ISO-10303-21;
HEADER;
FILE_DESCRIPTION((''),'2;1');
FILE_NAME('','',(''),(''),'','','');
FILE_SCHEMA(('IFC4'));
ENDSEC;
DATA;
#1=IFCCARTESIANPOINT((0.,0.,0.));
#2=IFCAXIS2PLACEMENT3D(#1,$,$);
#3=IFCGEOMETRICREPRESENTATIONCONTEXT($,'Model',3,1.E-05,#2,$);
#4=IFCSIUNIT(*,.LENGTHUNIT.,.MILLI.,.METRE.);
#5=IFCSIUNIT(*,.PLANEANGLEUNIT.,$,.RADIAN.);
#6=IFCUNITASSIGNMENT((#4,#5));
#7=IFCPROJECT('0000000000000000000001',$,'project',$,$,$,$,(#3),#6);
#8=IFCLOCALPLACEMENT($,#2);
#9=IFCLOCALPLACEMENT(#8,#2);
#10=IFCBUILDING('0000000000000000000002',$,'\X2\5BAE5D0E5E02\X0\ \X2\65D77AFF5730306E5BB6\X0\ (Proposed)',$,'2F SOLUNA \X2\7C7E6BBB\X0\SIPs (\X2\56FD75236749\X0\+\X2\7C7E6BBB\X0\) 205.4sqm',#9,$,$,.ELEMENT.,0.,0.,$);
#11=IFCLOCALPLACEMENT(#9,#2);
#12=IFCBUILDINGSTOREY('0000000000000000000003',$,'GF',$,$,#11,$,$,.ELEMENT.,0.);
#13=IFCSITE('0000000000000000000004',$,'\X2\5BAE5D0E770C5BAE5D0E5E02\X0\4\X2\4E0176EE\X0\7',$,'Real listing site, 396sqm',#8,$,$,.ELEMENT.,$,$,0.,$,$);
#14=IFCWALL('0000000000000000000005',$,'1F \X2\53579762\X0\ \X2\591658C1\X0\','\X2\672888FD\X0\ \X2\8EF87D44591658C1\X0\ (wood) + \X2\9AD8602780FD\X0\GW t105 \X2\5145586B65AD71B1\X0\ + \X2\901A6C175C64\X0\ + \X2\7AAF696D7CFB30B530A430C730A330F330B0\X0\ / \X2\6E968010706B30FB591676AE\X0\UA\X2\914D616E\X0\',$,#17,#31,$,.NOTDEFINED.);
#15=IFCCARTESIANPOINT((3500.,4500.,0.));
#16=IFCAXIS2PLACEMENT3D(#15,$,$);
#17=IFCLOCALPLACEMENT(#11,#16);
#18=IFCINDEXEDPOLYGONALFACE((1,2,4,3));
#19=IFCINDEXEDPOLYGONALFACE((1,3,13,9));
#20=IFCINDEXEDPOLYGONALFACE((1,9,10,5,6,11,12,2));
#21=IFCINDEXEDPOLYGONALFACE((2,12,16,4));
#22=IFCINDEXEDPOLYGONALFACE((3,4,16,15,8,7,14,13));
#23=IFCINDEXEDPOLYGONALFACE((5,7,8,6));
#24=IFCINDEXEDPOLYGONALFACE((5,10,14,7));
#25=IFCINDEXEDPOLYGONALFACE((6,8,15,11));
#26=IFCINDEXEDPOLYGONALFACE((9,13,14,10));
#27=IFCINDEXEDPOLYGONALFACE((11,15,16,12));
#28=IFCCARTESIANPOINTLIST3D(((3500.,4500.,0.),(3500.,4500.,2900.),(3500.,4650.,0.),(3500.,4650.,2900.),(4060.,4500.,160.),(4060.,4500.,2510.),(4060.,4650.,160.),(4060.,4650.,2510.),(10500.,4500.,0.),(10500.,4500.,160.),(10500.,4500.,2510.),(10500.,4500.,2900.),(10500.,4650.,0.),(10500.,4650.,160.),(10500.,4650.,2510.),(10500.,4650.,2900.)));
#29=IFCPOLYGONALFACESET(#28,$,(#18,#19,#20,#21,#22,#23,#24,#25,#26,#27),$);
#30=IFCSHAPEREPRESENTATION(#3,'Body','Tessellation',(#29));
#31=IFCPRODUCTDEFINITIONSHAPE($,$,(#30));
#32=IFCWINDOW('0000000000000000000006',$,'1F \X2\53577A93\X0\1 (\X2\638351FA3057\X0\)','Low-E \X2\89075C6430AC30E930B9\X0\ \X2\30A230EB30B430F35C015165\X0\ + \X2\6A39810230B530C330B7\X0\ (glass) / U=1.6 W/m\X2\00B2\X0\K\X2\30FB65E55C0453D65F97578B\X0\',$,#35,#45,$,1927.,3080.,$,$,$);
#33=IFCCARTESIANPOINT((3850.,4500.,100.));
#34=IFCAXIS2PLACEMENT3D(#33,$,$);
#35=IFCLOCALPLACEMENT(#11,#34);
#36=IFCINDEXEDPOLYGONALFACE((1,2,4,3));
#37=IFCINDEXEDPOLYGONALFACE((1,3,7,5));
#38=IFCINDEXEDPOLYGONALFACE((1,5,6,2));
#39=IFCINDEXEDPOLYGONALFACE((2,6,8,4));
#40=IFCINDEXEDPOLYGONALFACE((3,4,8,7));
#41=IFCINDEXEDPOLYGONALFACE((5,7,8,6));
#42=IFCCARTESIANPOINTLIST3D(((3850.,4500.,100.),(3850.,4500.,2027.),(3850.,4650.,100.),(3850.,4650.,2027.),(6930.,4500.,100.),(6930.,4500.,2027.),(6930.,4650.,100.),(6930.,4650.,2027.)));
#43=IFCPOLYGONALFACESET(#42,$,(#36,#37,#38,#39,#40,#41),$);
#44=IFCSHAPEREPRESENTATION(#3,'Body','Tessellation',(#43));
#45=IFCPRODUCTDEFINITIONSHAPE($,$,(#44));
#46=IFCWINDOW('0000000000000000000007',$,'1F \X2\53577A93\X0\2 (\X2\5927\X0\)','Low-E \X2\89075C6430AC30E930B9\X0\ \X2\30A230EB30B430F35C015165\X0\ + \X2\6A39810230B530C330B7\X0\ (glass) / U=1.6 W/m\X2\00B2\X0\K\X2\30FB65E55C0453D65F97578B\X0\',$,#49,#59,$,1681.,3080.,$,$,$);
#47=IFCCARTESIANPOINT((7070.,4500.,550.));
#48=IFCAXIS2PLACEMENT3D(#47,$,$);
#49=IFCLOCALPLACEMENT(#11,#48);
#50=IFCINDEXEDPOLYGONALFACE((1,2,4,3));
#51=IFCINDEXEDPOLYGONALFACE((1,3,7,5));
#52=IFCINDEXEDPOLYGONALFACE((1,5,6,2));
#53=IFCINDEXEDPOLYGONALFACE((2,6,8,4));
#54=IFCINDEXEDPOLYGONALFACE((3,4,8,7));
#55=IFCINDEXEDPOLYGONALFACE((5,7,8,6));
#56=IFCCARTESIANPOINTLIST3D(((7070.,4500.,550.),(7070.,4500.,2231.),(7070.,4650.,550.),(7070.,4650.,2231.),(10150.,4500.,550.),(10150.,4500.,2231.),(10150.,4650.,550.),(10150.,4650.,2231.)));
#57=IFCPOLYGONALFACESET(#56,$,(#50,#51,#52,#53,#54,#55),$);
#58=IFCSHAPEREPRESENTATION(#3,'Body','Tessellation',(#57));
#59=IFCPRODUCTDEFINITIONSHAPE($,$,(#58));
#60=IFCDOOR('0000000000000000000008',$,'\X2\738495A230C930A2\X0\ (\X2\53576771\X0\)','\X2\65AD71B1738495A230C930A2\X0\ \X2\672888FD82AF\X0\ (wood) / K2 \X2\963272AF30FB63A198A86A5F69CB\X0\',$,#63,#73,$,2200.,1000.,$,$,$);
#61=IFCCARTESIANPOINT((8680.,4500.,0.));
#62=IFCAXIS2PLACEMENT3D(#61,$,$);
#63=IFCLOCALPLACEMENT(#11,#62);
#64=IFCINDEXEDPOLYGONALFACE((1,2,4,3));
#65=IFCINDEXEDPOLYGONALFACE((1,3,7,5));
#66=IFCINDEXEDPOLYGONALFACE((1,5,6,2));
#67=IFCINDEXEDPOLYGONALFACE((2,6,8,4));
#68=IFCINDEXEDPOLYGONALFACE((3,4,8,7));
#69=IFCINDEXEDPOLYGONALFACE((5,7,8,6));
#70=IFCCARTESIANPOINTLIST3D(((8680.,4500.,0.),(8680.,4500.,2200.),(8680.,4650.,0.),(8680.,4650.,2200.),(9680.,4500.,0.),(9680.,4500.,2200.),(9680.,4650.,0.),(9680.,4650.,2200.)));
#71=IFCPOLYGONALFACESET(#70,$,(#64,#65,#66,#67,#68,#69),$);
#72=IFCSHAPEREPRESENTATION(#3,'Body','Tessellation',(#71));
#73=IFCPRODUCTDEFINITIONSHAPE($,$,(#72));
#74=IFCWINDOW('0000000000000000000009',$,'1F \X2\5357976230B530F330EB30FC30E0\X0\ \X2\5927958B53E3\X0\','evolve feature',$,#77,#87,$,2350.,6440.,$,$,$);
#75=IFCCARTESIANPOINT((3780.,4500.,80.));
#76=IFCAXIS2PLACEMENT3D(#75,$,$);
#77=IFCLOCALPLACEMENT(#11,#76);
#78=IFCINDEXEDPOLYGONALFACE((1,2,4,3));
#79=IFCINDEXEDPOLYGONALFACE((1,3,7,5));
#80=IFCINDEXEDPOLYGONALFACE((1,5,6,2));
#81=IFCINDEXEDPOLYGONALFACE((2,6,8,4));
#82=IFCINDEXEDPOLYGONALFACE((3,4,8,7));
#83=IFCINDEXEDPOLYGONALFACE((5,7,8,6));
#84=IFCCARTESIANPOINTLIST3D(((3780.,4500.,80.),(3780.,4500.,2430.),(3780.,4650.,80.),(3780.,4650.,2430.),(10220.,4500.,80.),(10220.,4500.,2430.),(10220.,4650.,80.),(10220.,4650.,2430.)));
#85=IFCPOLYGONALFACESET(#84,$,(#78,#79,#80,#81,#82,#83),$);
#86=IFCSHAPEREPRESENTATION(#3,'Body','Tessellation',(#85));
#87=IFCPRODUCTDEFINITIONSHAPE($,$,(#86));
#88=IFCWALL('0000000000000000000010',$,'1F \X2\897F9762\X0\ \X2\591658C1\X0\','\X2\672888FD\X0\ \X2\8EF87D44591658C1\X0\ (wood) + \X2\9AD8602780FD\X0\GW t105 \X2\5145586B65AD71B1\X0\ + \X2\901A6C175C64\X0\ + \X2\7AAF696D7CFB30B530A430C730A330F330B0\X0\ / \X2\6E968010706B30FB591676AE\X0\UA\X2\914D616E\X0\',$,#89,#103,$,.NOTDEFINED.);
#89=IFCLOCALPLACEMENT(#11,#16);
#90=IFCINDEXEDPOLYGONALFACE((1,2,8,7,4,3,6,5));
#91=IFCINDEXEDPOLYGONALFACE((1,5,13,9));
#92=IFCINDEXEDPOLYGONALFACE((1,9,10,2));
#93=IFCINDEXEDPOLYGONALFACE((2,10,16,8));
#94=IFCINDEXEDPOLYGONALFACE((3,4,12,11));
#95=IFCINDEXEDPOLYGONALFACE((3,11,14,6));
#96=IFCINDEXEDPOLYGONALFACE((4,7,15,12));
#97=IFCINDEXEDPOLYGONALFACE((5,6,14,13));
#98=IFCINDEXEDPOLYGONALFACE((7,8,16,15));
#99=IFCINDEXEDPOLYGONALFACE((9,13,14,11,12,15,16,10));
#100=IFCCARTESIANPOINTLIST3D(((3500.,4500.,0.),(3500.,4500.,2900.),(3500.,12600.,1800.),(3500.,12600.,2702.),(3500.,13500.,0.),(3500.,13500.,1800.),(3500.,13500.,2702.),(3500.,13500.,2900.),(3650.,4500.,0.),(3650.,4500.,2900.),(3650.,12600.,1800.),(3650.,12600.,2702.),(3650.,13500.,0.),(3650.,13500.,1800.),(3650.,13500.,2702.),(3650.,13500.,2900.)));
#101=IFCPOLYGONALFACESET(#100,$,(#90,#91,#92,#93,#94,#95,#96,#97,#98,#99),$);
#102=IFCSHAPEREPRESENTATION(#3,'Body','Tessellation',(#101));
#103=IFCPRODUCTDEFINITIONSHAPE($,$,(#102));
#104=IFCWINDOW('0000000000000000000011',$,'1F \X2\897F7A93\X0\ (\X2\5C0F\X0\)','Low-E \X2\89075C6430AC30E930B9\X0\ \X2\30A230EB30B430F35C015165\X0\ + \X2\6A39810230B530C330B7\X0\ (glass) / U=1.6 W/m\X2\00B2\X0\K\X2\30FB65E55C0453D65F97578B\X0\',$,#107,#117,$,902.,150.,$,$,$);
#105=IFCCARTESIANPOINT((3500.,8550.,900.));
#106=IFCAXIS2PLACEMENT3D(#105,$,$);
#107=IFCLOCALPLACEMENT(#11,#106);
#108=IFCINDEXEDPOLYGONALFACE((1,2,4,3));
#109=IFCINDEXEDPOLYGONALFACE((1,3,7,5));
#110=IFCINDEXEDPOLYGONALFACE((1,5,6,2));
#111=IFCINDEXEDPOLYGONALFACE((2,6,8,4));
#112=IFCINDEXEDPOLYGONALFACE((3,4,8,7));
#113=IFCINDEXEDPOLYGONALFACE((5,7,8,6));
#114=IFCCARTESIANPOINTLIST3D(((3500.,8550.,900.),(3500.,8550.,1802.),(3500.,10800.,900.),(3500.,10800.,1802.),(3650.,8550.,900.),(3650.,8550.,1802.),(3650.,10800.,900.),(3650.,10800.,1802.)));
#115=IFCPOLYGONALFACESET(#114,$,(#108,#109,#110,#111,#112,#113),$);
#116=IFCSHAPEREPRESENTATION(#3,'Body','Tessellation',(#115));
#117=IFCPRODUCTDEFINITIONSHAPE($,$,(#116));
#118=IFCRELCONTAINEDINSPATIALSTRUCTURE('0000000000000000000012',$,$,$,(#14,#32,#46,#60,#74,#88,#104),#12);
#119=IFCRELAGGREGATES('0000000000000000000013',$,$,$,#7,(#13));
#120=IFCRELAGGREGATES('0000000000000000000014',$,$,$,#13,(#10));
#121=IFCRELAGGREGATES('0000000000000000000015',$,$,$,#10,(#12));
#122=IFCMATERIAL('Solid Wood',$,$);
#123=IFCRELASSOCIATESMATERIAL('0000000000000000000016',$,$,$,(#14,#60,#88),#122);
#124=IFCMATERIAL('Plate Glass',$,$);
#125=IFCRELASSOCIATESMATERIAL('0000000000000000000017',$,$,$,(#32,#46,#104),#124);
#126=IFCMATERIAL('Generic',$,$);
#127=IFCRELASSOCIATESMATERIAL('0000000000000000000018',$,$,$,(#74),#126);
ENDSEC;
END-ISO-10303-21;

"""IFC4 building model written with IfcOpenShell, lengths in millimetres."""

from ifc_helpers import new_model, si_unit, frame, frame_2d, origin, place, context, project, spatial, rectangle, extrude, material, element, fill, save


model = new_model("IFC4")

# Units and contexts
model_context = context("Model", 3, precision=1e-05, world=origin())
ifc_project = project(units=[si_unit("LENGTHUNIT", "METRE", prefix="MILLI"), si_unit("PLANEANGLEUNIT", "RADIAN")], contexts=[model_context])

# Site, building, storey
site_placement = place(None, origin())
site = spatial("IfcSite", under=ifc_project, at=site_placement, Name="宮崎県宮崎市4丁目7", ObjectType="Real listing site, 396sqm", CompositionType="ELEMENT", RefElevation=0.0)
building_placement = place(site_placement, origin())
building = spatial("IfcBuilding", under=site, at=building_placement, Name="宮崎市 旗竿地の家 (Proposed)", ObjectType="2F SOLUNA 籾殻SIPs (国産杉+籾殻) 205.4sqm", CompositionType="ELEMENT", ElevationOfRefHeight=0.0, ElevationOfTerrain=0.0)
storey_placement = place(building_placement, origin())
storey = spatial("IfcBuildingStorey", under=building, at=storey_placement, Name="GF", CompositionType="ELEMENT", Elevation=0.0)

# Shared definitions
ifc_material_1 = material(Name="Solid Wood")

# Wall, openings, windows, door
wall_1_placement = place(storey_placement, frame((3500.0, 4500.0, 0.0)))
wall_1 = element("IfcWall", 1, at=wall_1_placement, inside=storey, material=ifc_material_1, Name="1F 南面 外壁", Description="木製 軸組外壁 (wood) + 高性能GW t105 充填断熱 + 通気層 + 窯業系サイディング / 準耐火・外皮UA配慮", PredefinedType="NOTDEFINED", context=model_context, shape_type="SweptSolid", body=[
    extrude(rectangle(XDim=7000.0, YDim=150.0, at=frame_2d((3500.0, 75.0))), frame((3500.0, 4500.0, 0.0)), (0.0, 0.0, 1.0), 2900.0),
])
opening_1_placement = place(storey_placement, frame((3850.0, 4500.0, 100.0)))
opening_1 = element("IfcOpeningElement", 2, at=opening_1_placement, cuts=wall_1, PredefinedType="NOTDEFINED", context=model_context, shape_type="SweptSolid", body=[
    extrude(rectangle(XDim=3080.0, YDim=150.0, at=frame_2d((1540.0, 75.0))), frame((3850.0, 4500.0, 100.0)), (0.0, 0.0, 1.0), 1927.0),
])
opening_2_placement = place(storey_placement, frame((7070.0, 4500.0, 550.0)))
opening_2 = element("IfcOpeningElement", 3, at=opening_2_placement, cuts=wall_1, PredefinedType="NOTDEFINED", context=model_context, shape_type="SweptSolid", body=[
    extrude(rectangle(XDim=3080.0, YDim=150.0, at=frame_2d((1540.0, 75.0))), frame((7070.0, 4500.0, 550.0)), (0.0, 0.0, 1.0), 1681.0),
])
opening_3_placement = place(storey_placement, frame((8680.0, 4500.0, 0.0)))
opening_3 = element("IfcOpeningElement", 4, at=opening_3_placement, cuts=wall_1, PredefinedType="NOTDEFINED", context=model_context, shape_type="SweptSolid", body=[
    extrude(rectangle(XDim=1000.0, YDim=150.0, at=frame_2d((500.0, 75.0))), frame((8680.0, 4500.0, 0.0)), (0.0, 0.0, 1.0), 2200.0),
])
opening_4_placement = place(storey_placement, frame((3780.0, 4500.0, 80.0)))
opening_4 = element("IfcOpeningElement", 5, at=opening_4_placement, cuts=wall_1, PredefinedType="NOTDEFINED", context=model_context, shape_type="SweptSolid", body=[
    extrude(rectangle(XDim=6440.0, YDim=150.0, at=frame_2d((3220.0, 75.0))), frame((3780.0, 4500.0, 80.0)), (0.0, 0.0, 1.0), 2350.0),
])
ifc_material_2 = material(Name="Plate Glass")
window_1_placement = place(storey_placement, frame((3850.0, 4500.0, 100.0)))
window_1 = element("IfcWindow", 6, at=window_1_placement, inside=storey, material=ifc_material_2, Name="1F 南窓1 (掃出し)", Description="Low-E 複層ガラス アルゴン封入 + 樹脂サッシ (glass) / U=1.6 W/m²K・日射取得型", OverallHeight=1927.0, OverallWidth=3080.0, context=model_context, shape_type="SweptSolid", body=[
    extrude(rectangle(XDim=3080.0, YDim=150.0, at=frame_2d((1540.0, 75.0))), frame((3850.0, 4500.0, 100.0)), (0.0, 0.0, 1.0), 1927.0),
])
fill(opening_1, window_1)
window_2_placement = place(storey_placement, frame((7070.0, 4500.0, 550.0)))
window_2 = element("IfcWindow", 7, at=window_2_placement, inside=storey, material=ifc_material_2, Name="1F 南窓2 (大)", Description="Low-E 複層ガラス アルゴン封入 + 樹脂サッシ (glass) / U=1.6 W/m²K・日射取得型", OverallHeight=1681.0, OverallWidth=3080.0, context=model_context, shape_type="SweptSolid", body=[
    extrude(rectangle(XDim=3080.0, YDim=150.0, at=frame_2d((1540.0, 75.0))), frame((7070.0, 4500.0, 550.0)), (0.0, 0.0, 1.0), 1681.0),
])
fill(opening_2, window_2)
door_placement = place(storey_placement, frame((8680.0, 4500.0, 0.0)))
door = element("IfcDoor", 8, at=door_placement, inside=storey, material=ifc_material_1, Name="玄関ドア (南東)", Description="断熱玄関ドア 木製芯 (wood) / K2 防犯・採風機構", OverallHeight=2200.0, OverallWidth=1000.0, context=model_context, shape_type="SweptSolid", body=[
    extrude(rectangle(XDim=1000.0, YDim=150.0, at=frame_2d((500.0, 75.0))), frame((8680.0, 4500.0, 0.0)), (0.0, 0.0, 1.0), 2200.0),
])
fill(opening_3, door)
ifc_material_3 = material(Name="Generic")
window_3_placement = place(storey_placement, frame((3780.0, 4500.0, 80.0)))
window_3 = element("IfcWindow", 9, at=window_3_placement, inside=storey, material=ifc_material_3, Name="1F 南面サンルーム 大開口", Description="evolve feature", OverallHeight=2350.0, OverallWidth=6440.0, context=model_context, shape_type="SweptSolid", body=[
    extrude(rectangle(XDim=6440.0, YDim=150.0, at=frame_2d((3220.0, 75.0))), frame((3780.0, 4500.0, 80.0)), (0.0, 0.0, 1.0), 2350.0),
])
fill(opening_4, window_3)

# Wall, opening, window
wall_2_placement = place(storey_placement, frame((3500.0, 4500.0, 0.0)))
wall_2 = element("IfcWall", 10, at=wall_2_placement, inside=storey, material=ifc_material_1, Name="1F 西面 外壁", Description="木製 軸組外壁 (wood) + 高性能GW t105 充填断熱 + 通気層 + 窯業系サイディング / 準耐火・外皮UA配慮", PredefinedType="NOTDEFINED", context=model_context, shape_type="SweptSolid", body=[
    extrude(rectangle(XDim=150.0, YDim=9000.0, at=frame_2d((75.0, 4500.0))), frame((3500.0, 4500.0, 0.0)), (0.0, 0.0, 1.0), 2900.0),
])
opening_5_placement = place(storey_placement, frame((3500.0, 8550.0, 900.0)))
opening_5 = element("IfcOpeningElement", 11, at=opening_5_placement, cuts=wall_2, PredefinedType="NOTDEFINED", context=model_context, shape_type="SweptSolid", body=[
    extrude(rectangle(XDim=150.0, YDim=2250.0, at=frame_2d((75.0, 1125.0))), frame((3500.0, 8550.0, 900.0)), (0.0, 0.0, 1.0), 902.0),
])
window_4_placement = place(storey_placement, frame((3500.0, 8550.0, 900.0)))
window_4 = element("IfcWindow", 12, at=window_4_placement, inside=storey, material=ifc_material_2, Name="1F 西窓 (小)", Description="Low-E 複層ガラス アルゴン封入 + 樹脂サッシ (glass) / U=1.6 W/m²K・日射取得型", OverallHeight=902.0, OverallWidth=150.0, context=model_context, shape_type="SweptSolid", body=[
    extrude(rectangle(XDim=150.0, YDim=2250.0, at=frame_2d((75.0, 1125.0))), frame((3500.0, 8550.0, 900.0)), (0.0, 0.0, 1.0), 902.0),
])
fill(opening_5, window_4)

save(model, "model.ifc")
